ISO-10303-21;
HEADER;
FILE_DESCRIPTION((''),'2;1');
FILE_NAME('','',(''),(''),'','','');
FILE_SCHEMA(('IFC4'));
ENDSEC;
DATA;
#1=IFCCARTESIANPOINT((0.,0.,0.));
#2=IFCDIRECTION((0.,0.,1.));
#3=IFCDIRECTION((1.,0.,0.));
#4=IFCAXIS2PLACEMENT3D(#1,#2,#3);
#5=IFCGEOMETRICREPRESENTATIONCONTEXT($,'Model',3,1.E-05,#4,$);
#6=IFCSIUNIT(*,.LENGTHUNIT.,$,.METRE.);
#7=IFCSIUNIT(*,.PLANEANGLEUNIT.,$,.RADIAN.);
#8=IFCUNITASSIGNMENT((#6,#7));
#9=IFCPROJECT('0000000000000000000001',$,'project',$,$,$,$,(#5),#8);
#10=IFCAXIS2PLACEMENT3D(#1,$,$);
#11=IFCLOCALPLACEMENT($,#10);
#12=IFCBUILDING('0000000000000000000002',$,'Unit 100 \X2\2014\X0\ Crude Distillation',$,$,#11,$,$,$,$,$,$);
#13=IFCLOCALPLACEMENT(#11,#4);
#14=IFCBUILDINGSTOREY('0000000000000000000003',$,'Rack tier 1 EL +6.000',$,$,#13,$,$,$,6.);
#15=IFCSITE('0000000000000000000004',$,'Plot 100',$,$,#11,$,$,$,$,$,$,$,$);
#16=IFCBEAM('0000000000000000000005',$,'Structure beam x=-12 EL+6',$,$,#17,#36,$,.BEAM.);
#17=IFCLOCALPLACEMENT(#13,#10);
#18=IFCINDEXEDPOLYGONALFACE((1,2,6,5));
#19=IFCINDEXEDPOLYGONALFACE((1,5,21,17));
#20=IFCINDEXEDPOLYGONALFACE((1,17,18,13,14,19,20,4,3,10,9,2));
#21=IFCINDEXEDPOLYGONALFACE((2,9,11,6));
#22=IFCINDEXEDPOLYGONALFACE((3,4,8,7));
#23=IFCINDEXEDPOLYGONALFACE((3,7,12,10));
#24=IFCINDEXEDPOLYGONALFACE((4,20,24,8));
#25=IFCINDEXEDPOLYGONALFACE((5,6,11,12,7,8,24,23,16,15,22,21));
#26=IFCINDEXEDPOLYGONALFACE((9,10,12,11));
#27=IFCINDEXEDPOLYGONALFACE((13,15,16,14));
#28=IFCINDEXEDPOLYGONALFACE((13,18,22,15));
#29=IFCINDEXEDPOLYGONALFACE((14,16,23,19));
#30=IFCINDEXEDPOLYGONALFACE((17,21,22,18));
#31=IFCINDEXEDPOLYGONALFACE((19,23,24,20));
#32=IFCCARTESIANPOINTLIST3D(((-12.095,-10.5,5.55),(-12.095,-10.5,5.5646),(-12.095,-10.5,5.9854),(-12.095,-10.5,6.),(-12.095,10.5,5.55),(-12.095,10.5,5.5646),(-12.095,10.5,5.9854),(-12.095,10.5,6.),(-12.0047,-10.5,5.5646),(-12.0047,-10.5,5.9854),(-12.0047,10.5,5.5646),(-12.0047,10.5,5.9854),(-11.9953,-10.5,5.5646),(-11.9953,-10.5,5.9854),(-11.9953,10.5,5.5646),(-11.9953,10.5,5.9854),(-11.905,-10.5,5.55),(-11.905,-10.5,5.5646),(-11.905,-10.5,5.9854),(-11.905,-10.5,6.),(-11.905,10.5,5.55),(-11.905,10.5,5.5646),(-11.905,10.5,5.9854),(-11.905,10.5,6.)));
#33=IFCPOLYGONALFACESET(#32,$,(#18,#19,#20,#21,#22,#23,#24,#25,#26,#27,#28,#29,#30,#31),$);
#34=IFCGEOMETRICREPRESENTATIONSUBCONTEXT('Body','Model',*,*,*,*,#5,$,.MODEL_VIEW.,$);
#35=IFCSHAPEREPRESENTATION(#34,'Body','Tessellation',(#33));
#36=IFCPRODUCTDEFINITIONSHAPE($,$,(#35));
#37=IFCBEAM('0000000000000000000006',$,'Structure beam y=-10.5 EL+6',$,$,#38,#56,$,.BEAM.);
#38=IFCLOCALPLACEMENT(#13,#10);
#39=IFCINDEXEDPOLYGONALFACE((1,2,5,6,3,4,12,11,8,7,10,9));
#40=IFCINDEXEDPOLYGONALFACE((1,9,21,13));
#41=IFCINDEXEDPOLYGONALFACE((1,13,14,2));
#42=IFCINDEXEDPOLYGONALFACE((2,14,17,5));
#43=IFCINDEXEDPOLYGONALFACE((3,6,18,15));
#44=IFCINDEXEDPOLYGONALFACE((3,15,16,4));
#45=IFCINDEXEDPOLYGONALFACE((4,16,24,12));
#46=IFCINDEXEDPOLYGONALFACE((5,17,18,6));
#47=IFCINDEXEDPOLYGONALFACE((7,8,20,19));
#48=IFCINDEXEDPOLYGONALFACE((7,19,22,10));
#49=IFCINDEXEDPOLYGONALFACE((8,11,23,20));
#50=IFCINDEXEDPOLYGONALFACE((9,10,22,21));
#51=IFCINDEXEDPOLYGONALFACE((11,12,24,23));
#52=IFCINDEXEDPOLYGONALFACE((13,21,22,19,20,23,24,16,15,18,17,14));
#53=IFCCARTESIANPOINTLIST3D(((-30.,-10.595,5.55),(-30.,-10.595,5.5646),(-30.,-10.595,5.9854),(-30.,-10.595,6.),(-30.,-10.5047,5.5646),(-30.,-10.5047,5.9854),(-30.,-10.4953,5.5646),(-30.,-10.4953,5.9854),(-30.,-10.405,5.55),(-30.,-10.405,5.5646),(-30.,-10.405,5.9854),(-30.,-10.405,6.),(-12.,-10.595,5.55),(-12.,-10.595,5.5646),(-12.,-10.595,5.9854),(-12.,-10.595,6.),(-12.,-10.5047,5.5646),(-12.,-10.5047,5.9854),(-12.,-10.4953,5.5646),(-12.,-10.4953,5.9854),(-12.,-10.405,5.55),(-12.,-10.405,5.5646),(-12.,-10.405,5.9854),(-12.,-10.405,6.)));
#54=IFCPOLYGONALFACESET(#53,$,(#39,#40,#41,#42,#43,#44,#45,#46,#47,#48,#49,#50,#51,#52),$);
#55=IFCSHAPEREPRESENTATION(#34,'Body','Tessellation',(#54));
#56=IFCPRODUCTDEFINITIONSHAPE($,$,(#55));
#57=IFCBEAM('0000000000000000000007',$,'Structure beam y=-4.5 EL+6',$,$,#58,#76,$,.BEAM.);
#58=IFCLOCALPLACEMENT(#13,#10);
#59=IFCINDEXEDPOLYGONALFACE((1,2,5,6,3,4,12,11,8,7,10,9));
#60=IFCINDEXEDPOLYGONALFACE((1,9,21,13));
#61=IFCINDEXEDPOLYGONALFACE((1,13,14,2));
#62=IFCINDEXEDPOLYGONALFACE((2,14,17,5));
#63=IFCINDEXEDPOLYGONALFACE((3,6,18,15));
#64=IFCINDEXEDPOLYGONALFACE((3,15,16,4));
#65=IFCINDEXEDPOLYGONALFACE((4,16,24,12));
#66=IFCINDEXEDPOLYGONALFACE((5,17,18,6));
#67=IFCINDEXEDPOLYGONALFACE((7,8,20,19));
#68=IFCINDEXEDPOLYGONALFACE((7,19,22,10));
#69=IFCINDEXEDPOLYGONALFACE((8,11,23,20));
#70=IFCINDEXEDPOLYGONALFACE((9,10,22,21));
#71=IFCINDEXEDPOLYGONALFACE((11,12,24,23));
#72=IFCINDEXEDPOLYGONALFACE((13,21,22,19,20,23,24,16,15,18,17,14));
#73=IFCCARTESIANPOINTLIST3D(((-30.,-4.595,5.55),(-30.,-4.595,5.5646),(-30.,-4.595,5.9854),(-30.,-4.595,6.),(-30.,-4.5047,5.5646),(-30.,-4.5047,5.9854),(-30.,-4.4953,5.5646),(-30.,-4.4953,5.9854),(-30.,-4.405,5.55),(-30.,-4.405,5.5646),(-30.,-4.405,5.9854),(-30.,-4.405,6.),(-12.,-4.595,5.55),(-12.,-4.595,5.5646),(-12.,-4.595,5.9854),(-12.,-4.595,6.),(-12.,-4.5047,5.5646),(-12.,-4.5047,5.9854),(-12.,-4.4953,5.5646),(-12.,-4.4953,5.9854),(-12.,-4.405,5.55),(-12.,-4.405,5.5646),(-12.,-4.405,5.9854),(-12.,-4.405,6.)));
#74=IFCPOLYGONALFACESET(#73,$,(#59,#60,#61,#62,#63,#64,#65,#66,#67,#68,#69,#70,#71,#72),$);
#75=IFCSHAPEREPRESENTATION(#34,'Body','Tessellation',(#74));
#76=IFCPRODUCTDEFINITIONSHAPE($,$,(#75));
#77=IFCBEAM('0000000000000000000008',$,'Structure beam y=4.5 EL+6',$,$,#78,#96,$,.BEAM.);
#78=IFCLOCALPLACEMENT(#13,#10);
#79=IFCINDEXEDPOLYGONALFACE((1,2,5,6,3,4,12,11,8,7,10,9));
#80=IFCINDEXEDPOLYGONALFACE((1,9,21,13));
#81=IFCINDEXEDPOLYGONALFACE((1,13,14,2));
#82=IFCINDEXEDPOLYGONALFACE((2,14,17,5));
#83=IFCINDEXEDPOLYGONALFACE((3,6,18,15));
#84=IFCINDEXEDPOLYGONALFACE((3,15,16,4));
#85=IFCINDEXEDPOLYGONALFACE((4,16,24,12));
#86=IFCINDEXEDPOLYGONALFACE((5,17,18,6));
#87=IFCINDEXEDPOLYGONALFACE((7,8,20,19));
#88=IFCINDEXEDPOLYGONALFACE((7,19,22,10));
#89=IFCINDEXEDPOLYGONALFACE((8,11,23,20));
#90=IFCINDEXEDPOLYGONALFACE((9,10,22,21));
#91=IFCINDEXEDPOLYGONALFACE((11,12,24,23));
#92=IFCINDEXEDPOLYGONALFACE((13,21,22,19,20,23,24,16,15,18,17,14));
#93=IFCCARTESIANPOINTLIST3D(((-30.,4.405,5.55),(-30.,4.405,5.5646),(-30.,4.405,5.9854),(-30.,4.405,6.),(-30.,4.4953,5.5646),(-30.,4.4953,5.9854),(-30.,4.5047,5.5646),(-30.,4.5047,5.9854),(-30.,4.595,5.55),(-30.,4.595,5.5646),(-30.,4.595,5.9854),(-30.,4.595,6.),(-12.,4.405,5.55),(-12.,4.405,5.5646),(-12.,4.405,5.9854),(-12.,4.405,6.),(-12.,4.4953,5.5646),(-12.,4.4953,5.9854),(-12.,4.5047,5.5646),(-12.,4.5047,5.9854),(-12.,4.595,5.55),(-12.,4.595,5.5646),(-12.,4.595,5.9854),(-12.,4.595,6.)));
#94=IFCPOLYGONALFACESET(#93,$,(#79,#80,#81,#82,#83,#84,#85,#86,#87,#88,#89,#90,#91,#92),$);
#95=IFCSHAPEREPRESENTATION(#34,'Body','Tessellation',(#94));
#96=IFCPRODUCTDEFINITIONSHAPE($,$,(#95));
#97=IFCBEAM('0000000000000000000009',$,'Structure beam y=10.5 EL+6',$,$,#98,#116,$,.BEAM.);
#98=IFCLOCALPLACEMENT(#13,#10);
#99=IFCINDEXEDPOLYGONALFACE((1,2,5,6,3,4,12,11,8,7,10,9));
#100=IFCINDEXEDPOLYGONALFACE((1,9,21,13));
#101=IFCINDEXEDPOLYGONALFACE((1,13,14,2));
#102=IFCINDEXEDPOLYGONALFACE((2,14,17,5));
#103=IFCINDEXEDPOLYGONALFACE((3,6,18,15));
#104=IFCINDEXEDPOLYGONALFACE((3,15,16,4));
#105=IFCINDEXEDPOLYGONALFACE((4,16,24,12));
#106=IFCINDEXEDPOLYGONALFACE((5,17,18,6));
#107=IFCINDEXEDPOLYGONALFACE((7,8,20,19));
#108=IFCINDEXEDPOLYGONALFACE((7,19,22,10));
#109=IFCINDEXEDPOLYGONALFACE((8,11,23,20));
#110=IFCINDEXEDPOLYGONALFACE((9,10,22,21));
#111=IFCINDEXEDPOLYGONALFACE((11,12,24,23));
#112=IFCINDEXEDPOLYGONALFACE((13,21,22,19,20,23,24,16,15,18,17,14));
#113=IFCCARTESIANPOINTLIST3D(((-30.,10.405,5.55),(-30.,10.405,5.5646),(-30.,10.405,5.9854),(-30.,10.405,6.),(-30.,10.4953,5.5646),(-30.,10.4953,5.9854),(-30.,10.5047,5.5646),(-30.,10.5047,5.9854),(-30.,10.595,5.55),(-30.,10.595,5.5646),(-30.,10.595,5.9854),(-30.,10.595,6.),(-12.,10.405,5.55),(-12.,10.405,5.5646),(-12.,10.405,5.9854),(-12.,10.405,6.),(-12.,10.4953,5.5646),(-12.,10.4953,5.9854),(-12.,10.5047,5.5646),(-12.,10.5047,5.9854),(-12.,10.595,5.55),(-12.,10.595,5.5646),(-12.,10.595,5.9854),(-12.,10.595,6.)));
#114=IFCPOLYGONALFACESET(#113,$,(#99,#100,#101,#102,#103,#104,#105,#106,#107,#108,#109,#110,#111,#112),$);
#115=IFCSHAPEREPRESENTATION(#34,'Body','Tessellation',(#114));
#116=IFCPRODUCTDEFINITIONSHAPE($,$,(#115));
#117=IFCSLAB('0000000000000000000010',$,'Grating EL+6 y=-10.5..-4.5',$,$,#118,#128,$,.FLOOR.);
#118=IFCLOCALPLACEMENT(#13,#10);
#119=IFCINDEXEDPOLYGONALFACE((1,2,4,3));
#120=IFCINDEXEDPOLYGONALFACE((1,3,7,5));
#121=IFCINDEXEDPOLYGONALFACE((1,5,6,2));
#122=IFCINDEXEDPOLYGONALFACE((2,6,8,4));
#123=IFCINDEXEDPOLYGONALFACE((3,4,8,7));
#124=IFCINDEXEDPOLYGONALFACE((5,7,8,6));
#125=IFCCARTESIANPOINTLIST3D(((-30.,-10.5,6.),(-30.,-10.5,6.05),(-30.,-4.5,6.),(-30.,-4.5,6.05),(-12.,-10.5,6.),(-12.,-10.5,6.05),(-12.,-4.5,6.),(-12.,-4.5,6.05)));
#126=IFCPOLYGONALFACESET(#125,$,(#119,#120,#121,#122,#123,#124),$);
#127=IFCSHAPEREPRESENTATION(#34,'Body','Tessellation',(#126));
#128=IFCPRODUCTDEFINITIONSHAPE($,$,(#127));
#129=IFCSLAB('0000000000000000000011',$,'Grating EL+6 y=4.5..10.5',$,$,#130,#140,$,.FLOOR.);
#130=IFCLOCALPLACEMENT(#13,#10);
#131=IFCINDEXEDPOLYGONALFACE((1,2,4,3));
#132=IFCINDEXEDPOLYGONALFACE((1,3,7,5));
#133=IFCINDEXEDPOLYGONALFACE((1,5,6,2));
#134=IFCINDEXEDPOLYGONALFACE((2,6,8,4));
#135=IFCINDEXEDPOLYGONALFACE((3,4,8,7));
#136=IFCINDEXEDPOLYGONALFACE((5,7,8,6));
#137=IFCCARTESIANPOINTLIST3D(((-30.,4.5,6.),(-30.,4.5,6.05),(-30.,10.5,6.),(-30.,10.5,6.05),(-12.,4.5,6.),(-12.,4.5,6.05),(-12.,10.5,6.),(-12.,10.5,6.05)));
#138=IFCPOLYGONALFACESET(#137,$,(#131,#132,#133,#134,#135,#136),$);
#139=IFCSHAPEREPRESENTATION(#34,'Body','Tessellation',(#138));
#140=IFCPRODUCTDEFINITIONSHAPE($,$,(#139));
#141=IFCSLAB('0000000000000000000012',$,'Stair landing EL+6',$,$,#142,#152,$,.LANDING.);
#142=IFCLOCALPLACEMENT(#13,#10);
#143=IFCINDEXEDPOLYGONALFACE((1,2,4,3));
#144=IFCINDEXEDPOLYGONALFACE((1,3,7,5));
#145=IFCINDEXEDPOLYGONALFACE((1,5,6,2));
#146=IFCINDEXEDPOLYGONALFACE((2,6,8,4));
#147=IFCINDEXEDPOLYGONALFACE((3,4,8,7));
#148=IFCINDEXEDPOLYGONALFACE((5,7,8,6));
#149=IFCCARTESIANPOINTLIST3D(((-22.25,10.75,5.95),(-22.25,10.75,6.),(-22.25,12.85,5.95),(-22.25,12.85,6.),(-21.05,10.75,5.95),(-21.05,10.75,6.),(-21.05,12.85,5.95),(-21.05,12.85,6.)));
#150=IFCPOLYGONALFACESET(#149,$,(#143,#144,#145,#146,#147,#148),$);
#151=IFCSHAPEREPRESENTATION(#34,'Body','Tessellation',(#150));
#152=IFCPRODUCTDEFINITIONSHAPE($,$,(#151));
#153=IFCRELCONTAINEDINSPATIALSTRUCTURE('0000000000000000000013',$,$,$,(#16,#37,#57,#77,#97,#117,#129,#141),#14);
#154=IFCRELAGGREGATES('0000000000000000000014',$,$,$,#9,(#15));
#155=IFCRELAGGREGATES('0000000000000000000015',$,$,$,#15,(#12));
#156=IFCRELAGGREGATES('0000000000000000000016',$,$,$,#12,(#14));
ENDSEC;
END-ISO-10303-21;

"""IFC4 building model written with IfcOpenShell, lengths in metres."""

from ifc_helpers import new_model, si_unit, frame, origin, origin_with_axes, origin_2d, place, context, subcontext, project, spatial, rectangle, i_section, extrude, element, save


model = new_model("IFC4")

# Units and contexts
model_context = context("Model", 3, precision=1e-05, world=origin_with_axes())
body_context = subcontext(model_context, "Body", "Model", "MODEL_VIEW")
ifc_project = project(units=[si_unit("LENGTHUNIT", "METRE"), si_unit("PLANEANGLEUNIT", "RADIAN")], contexts=[model_context])

# Site, building, storey
placement = place(None, origin())
site = spatial("IfcSite", under=ifc_project, at=placement, Name="Plot 100")
building = spatial("IfcBuilding", under=site, at=placement, Name="Unit 100 — Crude Distillation")
storey_placement = place(placement, origin_with_axes())
storey = spatial("IfcBuildingStorey", under=building, at=storey_placement, Name="Rack tier 1 EL +6.000", Elevation=6.0)

# Beams
beam_1_placement = place(storey_placement, origin_with_axes())
element("IfcBeam", 1, at=beam_1_placement, inside=storey, Name="Structure beam x=-12 EL+6", PredefinedType="BEAM", context=body_context, shape_type="SweptSolid", body=[
    extrude(i_section(OverallWidth=0.19, OverallDepth=0.45, WebThickness=0.0094, FlangeThickness=0.0146, at=origin_2d()), frame((-12.0, -10.5, 5.775), z_axis=(0.0, 1.0, 0.0), x_axis=(-1.0, 0.0, 0.0)), (0.0, 0.0, 1.0), 21.0),
])
beam_2_placement = place(storey_placement, origin_with_axes())
element("IfcBeam", 2, at=beam_2_placement, inside=storey, Name="Structure beam y=-10.5 EL+6", PredefinedType="BEAM", context=body_context, shape_type="SweptSolid", body=[
    extrude(i_section(OverallWidth=0.19, OverallDepth=0.45, WebThickness=0.0094, FlangeThickness=0.0146, at=origin_2d()), frame((-30.0, -10.5, 5.775), z_axis=(1.0, 0.0, 0.0), x_axis=(0.0, 1.0, 0.0)), (0.0, 0.0, 1.0), 18.0),
])
beam_3_placement = place(storey_placement, origin_with_axes())
element("IfcBeam", 3, at=beam_3_placement, inside=storey, Name="Structure beam y=-4.5 EL+6", PredefinedType="BEAM", context=body_context, shape_type="SweptSolid", body=[
    extrude(i_section(OverallWidth=0.19, OverallDepth=0.45, WebThickness=0.0094, FlangeThickness=0.0146, at=origin_2d()), frame((-30.0, -4.5, 5.775), z_axis=(1.0, 0.0, 0.0), x_axis=(0.0, 1.0, 0.0)), (0.0, 0.0, 1.0), 18.0),
])
beam_4_placement = place(storey_placement, origin_with_axes())
element("IfcBeam", 4, at=beam_4_placement, inside=storey, Name="Structure beam y=4.5 EL+6", PredefinedType="BEAM", context=body_context, shape_type="SweptSolid", body=[
    extrude(i_section(OverallWidth=0.19, OverallDepth=0.45, WebThickness=0.0094, FlangeThickness=0.0146, at=origin_2d()), frame((-30.0, 4.5, 5.775), z_axis=(1.0, 0.0, 0.0), x_axis=(0.0, 1.0, 0.0)), (0.0, 0.0, 1.0), 18.0),
])
beam_5_placement = place(storey_placement, origin_with_axes())
element("IfcBeam", 5, at=beam_5_placement, inside=storey, Name="Structure beam y=10.5 EL+6", PredefinedType="BEAM", context=body_context, shape_type="SweptSolid", body=[
    extrude(i_section(OverallWidth=0.19, OverallDepth=0.45, WebThickness=0.0094, FlangeThickness=0.0146, at=origin_2d()), frame((-30.0, 10.5, 5.775), z_axis=(1.0, 0.0, 0.0), x_axis=(0.0, 1.0, 0.0)), (0.0, 0.0, 1.0), 18.0),
])

# Slabs
slab_1_placement = place(storey_placement, origin_with_axes())
element("IfcSlab", 6, at=slab_1_placement, inside=storey, Name="Grating EL+6 y=-10.5..-4.5", PredefinedType="FLOOR", context=body_context, shape_type="SweptSolid", body=[
    extrude(rectangle(XDim=18.0, YDim=6.0, at=origin_2d()), frame((-21.0, -7.5, 6.0), z_axis=(0.0, 0.0, 1.0), x_axis=(1.0, 0.0, 0.0)), (0.0, 0.0, 1.0), 0.05),
])
slab_2_placement = place(storey_placement, origin_with_axes())
element("IfcSlab", 7, at=slab_2_placement, inside=storey, Name="Grating EL+6 y=4.5..10.5", PredefinedType="FLOOR", context=body_context, shape_type="SweptSolid", body=[
    extrude(rectangle(XDim=18.0, YDim=6.0, at=origin_2d()), frame((-21.0, 7.5, 6.0), z_axis=(0.0, 0.0, 1.0), x_axis=(1.0, 0.0, 0.0)), (0.0, 0.0, 1.0), 0.05),
])
slab_3_placement = place(storey_placement, origin_with_axes())
element("IfcSlab", 8, at=slab_3_placement, inside=storey, Name="Stair landing EL+6", PredefinedType="LANDING", context=body_context, shape_type="SweptSolid", body=[
    extrude(rectangle(XDim=1.2, YDim=2.1, at=origin_2d()), frame((-21.65, 11.8, 5.95), z_axis=(0.0, 0.0, 1.0), x_axis=(1.0, 0.0, 0.0)), (0.0, 0.0, 1.0), 0.05),
])

save(model, "model.ifc")
